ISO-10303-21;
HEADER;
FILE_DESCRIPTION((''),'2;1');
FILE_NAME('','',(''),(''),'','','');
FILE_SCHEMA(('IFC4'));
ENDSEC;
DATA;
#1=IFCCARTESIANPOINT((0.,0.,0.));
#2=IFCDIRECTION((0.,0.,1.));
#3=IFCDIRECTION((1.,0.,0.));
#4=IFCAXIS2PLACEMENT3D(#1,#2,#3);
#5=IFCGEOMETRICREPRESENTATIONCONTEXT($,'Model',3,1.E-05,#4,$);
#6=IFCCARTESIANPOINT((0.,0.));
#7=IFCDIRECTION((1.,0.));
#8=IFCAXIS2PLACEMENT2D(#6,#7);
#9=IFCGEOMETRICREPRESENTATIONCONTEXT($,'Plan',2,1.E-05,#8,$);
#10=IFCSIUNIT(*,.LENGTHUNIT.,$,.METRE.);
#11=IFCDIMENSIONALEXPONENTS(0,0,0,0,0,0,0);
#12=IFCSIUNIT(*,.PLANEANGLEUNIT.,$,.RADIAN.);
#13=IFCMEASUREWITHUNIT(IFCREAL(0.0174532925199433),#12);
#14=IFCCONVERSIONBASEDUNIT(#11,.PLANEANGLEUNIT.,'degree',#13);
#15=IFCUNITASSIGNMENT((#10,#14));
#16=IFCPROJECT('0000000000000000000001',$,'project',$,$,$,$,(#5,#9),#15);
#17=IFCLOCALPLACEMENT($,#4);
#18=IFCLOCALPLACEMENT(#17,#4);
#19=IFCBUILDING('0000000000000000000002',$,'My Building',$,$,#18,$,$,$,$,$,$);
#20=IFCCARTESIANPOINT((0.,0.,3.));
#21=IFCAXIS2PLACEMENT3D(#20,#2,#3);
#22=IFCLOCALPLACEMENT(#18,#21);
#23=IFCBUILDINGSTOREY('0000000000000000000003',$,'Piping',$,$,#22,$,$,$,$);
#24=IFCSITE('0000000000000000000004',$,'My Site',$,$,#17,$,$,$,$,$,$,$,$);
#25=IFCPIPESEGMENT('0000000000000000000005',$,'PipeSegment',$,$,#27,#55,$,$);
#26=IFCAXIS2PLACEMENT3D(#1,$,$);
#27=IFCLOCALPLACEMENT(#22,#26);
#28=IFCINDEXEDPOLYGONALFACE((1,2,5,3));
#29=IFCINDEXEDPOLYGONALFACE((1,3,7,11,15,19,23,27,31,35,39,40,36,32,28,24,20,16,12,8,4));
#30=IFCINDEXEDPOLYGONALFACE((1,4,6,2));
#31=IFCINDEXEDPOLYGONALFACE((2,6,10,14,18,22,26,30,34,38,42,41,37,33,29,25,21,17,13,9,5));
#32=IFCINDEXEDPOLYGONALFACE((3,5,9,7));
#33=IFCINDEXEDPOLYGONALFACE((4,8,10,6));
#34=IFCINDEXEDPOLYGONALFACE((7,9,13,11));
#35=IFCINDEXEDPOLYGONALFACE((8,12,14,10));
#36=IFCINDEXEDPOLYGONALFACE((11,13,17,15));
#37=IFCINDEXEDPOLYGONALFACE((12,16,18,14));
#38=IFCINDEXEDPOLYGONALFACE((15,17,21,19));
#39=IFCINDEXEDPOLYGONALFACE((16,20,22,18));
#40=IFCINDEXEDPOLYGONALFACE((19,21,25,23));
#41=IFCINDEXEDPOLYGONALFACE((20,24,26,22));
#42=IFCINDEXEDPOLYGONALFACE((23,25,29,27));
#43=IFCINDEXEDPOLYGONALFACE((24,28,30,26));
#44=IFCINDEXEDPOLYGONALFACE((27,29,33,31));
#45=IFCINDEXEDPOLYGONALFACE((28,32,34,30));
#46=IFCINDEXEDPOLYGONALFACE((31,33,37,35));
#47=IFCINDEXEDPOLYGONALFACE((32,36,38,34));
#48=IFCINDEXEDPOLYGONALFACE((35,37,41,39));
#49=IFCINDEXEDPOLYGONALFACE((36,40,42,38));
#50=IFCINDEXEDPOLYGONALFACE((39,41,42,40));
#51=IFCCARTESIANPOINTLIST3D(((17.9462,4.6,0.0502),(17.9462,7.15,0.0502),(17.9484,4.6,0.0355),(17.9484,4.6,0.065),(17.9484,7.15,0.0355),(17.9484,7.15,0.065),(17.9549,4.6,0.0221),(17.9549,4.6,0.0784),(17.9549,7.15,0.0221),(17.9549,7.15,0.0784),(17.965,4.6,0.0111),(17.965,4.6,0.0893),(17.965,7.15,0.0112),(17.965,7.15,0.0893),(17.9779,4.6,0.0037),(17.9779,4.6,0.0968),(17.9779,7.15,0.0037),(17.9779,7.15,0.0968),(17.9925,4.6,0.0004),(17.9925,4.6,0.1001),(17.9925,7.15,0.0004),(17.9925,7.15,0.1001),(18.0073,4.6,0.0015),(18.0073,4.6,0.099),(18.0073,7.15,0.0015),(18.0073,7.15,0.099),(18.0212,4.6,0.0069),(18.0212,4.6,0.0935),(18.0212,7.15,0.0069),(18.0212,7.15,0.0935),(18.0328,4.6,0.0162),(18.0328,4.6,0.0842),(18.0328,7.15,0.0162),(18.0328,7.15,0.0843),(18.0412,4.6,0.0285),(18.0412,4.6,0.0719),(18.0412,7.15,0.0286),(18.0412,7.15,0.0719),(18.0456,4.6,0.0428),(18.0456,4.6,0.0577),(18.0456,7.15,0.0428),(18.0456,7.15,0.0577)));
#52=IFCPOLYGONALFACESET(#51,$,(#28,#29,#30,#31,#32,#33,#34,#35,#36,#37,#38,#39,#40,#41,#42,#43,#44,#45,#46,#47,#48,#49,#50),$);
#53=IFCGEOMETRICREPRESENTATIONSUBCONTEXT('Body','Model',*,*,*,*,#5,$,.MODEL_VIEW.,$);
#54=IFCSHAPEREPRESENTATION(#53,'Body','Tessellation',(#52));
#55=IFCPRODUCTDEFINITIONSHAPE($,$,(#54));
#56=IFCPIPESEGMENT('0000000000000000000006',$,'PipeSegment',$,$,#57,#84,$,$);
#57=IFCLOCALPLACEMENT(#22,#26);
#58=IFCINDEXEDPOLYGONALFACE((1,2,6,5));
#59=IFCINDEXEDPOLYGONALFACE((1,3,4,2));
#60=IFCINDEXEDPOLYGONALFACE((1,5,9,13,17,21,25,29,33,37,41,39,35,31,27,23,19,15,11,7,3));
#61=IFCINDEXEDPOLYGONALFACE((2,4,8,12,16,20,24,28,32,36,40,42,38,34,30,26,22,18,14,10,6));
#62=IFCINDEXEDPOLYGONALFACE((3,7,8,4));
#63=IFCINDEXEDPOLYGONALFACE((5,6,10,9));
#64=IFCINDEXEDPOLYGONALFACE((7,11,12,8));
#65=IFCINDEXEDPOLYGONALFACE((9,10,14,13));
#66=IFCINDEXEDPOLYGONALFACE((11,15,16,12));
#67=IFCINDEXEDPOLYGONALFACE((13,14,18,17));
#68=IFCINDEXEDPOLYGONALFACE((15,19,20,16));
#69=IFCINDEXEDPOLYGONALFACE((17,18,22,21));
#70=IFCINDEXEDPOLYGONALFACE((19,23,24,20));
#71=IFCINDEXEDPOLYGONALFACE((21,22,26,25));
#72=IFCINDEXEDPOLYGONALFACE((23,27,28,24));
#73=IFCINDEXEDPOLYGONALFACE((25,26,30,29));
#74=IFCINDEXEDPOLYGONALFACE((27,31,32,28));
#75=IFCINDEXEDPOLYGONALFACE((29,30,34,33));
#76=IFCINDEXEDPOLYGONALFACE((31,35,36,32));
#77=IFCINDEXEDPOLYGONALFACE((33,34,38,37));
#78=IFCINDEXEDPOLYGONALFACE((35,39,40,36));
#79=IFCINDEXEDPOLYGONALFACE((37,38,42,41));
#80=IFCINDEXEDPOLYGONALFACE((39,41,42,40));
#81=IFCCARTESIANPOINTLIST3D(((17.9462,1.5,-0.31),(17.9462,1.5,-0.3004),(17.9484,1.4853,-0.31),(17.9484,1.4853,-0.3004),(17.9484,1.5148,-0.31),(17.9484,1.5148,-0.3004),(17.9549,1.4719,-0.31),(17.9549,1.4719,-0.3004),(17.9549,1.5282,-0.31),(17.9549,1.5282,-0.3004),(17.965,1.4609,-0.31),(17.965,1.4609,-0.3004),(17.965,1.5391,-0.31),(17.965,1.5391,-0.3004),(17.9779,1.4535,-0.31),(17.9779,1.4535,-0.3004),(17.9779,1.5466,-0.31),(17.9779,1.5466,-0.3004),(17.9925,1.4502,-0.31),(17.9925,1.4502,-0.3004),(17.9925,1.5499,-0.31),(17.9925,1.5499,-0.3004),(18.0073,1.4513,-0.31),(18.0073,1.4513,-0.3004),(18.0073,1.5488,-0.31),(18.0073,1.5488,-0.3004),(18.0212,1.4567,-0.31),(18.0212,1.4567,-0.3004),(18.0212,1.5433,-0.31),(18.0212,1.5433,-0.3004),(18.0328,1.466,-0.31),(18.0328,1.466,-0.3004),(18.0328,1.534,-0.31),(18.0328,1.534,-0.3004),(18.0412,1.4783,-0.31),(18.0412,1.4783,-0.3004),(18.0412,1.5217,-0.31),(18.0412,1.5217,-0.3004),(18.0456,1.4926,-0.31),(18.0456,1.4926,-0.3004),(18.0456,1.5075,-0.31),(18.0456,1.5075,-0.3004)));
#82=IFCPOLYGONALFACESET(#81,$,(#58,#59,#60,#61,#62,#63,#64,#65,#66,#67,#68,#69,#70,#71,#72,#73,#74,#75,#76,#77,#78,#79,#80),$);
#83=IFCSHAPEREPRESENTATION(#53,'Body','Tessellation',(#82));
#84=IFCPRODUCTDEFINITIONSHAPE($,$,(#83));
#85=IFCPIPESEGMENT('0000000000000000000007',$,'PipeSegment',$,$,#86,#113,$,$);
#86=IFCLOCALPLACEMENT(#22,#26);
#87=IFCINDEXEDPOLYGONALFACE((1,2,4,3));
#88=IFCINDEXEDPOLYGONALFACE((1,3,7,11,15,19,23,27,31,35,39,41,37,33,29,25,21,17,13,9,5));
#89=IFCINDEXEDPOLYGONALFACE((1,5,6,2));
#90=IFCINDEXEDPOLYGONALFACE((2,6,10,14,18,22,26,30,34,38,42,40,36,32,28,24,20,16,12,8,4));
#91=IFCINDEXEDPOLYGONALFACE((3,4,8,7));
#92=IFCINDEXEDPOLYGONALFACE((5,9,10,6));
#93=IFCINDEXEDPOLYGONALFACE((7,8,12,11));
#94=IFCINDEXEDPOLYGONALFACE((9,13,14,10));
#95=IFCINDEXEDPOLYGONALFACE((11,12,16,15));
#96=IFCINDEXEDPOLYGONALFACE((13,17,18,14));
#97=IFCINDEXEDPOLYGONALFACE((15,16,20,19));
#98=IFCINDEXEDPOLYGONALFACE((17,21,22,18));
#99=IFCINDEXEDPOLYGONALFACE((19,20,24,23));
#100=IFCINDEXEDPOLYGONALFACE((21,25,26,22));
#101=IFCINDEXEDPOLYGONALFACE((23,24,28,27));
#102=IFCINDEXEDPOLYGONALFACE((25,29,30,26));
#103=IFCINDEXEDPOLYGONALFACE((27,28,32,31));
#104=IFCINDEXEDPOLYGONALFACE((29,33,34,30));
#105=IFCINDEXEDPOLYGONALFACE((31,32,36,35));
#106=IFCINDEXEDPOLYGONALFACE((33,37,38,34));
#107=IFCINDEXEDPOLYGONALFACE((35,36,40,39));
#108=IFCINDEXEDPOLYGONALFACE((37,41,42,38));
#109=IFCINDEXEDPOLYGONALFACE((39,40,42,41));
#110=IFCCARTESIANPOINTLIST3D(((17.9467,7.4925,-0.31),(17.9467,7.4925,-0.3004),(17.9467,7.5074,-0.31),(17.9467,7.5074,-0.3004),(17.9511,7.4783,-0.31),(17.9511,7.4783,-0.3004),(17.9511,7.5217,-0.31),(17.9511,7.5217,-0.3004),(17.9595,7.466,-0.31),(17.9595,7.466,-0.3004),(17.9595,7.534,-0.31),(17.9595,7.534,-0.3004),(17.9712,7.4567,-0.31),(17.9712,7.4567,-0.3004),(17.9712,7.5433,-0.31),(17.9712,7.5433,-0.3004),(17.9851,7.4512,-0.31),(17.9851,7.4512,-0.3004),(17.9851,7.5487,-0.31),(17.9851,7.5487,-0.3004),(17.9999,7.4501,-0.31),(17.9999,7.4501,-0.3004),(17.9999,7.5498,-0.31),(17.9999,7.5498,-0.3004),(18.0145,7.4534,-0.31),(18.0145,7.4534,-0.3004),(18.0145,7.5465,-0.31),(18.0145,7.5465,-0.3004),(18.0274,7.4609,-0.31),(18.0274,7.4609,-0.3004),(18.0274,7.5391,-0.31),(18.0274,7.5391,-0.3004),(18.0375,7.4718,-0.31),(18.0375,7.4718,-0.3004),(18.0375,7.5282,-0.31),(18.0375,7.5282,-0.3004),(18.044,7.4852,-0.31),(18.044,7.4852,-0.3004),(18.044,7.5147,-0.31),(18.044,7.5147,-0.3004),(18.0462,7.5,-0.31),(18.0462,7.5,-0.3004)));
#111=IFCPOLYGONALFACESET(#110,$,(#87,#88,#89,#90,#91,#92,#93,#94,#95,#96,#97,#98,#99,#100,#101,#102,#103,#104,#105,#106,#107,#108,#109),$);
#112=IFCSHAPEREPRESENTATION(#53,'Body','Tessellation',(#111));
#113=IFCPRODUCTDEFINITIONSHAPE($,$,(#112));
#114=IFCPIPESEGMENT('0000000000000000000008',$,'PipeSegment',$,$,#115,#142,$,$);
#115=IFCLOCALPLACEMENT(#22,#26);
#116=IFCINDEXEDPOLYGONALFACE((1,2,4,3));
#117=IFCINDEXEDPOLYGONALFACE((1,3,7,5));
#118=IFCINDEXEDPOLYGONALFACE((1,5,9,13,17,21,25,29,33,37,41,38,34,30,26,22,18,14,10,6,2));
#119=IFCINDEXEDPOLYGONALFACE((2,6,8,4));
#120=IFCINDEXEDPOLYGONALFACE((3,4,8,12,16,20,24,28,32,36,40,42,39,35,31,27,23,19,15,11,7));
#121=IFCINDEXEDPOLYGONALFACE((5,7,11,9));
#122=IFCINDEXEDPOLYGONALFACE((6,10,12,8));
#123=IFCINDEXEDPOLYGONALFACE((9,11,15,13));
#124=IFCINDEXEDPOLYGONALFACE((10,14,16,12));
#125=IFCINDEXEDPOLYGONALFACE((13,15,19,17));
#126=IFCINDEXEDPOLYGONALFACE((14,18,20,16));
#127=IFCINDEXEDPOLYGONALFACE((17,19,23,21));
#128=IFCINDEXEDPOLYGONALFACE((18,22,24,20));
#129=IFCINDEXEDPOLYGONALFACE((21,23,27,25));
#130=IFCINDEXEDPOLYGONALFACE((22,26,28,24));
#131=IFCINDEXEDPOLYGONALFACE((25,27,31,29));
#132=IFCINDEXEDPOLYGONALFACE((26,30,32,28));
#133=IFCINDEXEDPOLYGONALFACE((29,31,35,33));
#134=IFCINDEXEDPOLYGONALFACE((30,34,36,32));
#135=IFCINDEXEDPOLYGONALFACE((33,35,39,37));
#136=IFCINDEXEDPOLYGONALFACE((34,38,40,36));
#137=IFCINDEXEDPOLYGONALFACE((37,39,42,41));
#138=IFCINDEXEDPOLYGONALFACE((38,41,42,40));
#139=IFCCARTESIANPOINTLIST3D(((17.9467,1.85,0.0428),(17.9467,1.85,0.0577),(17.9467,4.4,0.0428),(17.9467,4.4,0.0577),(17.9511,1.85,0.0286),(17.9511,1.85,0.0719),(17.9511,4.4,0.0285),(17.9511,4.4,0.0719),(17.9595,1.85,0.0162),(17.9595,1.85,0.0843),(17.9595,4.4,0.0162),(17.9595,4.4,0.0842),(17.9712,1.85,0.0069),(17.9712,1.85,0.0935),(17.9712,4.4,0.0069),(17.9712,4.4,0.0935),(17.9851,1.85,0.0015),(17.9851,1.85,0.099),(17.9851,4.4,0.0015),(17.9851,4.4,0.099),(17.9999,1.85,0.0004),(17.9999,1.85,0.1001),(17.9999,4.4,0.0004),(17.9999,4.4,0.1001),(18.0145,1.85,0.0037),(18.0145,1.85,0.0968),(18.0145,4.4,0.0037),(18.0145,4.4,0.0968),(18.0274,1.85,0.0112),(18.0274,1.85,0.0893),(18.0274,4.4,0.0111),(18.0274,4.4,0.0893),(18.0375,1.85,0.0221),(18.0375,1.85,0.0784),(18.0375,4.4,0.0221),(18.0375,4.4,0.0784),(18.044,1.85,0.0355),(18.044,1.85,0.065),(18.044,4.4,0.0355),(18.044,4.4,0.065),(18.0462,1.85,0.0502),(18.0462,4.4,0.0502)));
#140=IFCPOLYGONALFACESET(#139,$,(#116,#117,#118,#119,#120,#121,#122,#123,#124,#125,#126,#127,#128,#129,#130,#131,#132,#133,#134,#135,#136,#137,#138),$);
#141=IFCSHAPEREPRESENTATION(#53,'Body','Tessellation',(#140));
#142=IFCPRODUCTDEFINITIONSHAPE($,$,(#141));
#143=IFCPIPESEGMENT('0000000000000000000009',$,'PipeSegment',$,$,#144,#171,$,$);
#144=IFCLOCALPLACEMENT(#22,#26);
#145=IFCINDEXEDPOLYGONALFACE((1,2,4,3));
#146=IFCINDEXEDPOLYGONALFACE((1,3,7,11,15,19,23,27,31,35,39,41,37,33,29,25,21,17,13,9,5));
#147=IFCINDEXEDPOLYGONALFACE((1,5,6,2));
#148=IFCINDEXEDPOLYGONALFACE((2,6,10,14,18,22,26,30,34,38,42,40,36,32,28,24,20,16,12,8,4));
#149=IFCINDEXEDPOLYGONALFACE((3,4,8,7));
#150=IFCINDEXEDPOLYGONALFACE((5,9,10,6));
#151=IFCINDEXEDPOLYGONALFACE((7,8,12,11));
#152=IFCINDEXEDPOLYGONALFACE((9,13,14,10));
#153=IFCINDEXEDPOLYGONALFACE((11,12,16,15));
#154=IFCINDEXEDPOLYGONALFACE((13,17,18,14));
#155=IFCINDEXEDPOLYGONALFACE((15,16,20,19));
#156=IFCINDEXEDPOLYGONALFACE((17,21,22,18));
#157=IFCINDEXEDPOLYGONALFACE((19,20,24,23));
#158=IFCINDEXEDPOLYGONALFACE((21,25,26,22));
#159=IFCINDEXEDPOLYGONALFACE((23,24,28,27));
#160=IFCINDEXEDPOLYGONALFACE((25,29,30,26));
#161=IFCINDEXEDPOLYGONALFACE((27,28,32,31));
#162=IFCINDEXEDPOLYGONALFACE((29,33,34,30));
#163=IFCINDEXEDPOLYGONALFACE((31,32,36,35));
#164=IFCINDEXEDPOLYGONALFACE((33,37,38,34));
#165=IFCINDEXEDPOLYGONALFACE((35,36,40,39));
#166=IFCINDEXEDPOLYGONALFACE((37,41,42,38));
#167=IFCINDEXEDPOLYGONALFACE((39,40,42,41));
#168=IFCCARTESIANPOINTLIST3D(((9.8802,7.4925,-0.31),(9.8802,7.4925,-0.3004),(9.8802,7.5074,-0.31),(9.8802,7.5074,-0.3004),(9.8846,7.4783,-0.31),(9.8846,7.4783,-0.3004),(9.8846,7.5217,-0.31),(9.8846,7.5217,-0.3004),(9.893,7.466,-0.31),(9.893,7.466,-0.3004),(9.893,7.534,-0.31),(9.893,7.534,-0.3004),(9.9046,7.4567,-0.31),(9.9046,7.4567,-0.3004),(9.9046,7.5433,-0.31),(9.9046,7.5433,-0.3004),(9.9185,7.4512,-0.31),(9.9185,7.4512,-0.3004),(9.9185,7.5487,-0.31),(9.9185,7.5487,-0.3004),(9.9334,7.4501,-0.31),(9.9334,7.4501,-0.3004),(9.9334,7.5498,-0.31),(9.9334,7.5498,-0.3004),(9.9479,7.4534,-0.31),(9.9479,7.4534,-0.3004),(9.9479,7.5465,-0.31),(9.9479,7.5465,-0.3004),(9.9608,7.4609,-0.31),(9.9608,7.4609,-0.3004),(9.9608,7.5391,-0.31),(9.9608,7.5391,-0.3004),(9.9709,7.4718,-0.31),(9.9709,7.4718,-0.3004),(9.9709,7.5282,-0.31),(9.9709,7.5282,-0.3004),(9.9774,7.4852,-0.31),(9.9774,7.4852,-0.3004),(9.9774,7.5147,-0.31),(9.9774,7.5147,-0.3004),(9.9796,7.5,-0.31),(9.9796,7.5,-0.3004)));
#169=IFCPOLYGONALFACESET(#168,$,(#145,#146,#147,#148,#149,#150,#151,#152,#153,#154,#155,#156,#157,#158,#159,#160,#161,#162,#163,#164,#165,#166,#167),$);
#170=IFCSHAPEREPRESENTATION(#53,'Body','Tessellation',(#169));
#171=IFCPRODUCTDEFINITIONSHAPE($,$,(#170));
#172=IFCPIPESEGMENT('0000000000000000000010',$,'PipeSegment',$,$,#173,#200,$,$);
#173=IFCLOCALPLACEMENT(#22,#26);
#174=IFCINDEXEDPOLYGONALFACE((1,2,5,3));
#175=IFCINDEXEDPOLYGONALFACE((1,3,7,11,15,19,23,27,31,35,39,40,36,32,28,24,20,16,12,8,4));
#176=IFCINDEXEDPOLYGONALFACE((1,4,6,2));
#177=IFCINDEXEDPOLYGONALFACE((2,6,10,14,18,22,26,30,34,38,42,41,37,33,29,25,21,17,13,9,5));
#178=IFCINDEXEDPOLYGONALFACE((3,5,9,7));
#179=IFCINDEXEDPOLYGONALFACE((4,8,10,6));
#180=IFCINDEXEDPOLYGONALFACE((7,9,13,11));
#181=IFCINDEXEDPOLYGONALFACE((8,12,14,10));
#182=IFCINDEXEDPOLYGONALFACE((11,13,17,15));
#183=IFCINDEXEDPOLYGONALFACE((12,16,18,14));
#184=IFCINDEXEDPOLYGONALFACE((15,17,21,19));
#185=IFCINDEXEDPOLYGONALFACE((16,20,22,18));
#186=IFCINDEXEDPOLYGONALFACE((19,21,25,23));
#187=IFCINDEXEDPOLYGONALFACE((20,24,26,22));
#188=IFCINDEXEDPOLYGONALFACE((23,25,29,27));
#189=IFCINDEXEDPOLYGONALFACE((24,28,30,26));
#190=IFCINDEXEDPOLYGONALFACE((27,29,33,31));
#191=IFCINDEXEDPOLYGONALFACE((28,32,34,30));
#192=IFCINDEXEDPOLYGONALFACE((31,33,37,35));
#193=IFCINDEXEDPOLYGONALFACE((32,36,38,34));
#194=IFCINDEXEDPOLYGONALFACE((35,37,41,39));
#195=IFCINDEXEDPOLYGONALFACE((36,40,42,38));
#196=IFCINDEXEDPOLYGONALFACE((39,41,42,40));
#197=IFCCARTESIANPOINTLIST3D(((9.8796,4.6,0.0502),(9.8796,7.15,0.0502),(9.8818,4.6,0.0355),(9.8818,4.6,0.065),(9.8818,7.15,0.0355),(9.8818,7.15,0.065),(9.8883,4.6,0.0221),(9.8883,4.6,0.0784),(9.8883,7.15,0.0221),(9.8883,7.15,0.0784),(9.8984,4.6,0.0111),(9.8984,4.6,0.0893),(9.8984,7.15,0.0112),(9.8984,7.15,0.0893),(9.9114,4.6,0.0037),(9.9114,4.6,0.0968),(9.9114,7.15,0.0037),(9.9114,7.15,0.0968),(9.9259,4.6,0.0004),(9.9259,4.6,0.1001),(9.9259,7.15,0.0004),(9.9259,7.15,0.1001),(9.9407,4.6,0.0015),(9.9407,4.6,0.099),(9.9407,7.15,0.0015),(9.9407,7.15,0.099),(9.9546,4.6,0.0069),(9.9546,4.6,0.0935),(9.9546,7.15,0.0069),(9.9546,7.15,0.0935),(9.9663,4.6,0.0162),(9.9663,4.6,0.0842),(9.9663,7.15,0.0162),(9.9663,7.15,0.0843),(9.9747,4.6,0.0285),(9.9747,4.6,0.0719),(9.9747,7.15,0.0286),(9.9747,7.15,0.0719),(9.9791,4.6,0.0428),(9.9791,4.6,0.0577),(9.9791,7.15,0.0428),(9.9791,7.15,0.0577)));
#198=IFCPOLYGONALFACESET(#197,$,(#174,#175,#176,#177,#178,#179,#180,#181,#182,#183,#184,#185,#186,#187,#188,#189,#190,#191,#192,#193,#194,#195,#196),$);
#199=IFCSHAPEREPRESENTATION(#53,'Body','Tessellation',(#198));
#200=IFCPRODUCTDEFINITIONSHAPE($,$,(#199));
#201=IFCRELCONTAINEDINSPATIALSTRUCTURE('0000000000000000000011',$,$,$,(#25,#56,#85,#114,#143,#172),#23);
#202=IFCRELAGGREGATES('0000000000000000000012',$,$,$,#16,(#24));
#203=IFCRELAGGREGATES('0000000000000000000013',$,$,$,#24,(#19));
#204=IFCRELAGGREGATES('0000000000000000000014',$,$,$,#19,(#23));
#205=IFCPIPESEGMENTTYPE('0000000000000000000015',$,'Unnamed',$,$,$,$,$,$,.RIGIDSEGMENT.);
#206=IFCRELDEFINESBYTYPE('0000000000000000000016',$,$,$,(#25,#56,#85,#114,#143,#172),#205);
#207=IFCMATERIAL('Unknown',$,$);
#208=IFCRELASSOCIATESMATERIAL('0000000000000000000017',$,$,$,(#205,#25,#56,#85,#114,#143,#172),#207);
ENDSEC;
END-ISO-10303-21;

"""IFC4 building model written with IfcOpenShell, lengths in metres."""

from ifc_helpers import new_model, entity, si_unit, converted_unit, frame, origin_with_axes, origin_2d_with_axis, place, context, subcontext, project, spatial, circle, extrude, material, material_profile, profile_set, profile_usage, type_object, element, save


model = new_model("IFC4")

# Units and contexts
model_context = context("Model", 3, precision=1e-05, world=origin_with_axes())
plan_context = context("Plan", 2, precision=1e-05, world=origin_2d_with_axis())
body_context = subcontext(model_context, "Body", "Model", "MODEL_VIEW")
ifc_project = project(units=[si_unit("LENGTHUNIT", "METRE"), converted_unit("PLANEANGLEUNIT", "degree", entity("IfcReal", 0.0174532925199433), si_unit("PLANEANGLEUNIT", "RADIAN"), dimensions=[0, 0, 0, 0, 0, 0, 0])], contexts=[model_context, plan_context])

# Site, building, storey
site_placement = place(None, origin_with_axes())
site = spatial("IfcSite", under=ifc_project, at=site_placement, Name="My Site")
building_placement = place(site_placement, origin_with_axes())
building = spatial("IfcBuilding", under=site, at=building_placement, Name="My Building")
storey_placement = place(building_placement, frame((0.0, 0.0, 3.0), z_axis=(0.0, 0.0, 1.0), x_axis=(1.0, 0.0, 0.0)))
storey = spatial("IfcBuildingStorey", under=building, at=storey_placement, Name="Piping")

# Pipe segments
ifc_material = material(Name="Unknown")
ifc_material_profile_1 = material_profile(ifc_material, circle(Radius=0.05))
ifc_profile_set_1 = profile_set([ifc_material_profile_1])
ifc_profile_usage_1 = profile_usage(ifc_profile_set_1, cardinal=2)
pipe_segment_type = type_object("IfcPipeSegmentType", Name="Unnamed", PredefinedType="RIGIDSEGMENT", material=ifc_profile_set_1)
pipe_segment_1_placement = place(storey_placement, frame((17.9962, 4.6, 0.0002), z_axis=(0.0, 1.0, 0.000006), x_axis=(-1.0, 0.0, 0.0)))
element("IfcPipeSegment", 1, at=pipe_segment_1_placement, inside=storey, type_object=pipe_segment_type, material=ifc_profile_usage_1, Name="PipeSegment", context=body_context, shape_type="SweptSolid", body=[
    extrude(circle(Radius=0.05), frame((0.0, 0.05, 0.0), z_axis=(0.0, 0.0, 1.0), x_axis=(1.0, 0.0, 0.0)), (0.0, 0.0, 1.0), 2.55),
])
ifc_profile_usage_2 = profile_usage(ifc_profile_set_1, cardinal=16)
pipe_segment_2_placement = place(storey_placement, frame((17.9962, 1.5, -0.3004), z_axis=(0.0, 0.0, -1.0), x_axis=(-1.0, 0.0, 0.0)))
element("IfcPipeSegment", 2, at=pipe_segment_2_placement, inside=storey, type_object=pipe_segment_type, material=ifc_profile_usage_2, Name="PipeSegment", context=body_context, shape_type="SweptSolid", body=[
    extrude(circle(Radius=0.05), origin_with_axes(), (0.0, 0.0, 1.0), 0.0096),
])
ifc_profile_usage_3 = profile_usage(ifc_profile_set_1, cardinal=16)
pipe_segment_3_placement = place(storey_placement, frame((17.9962, 7.5, -0.3004), z_axis=(0.0, 0.0, -1.0), x_axis=(1.0, 0.0, 0.0)))
element("IfcPipeSegment", 3, at=pipe_segment_3_placement, inside=storey, type_object=pipe_segment_type, material=ifc_profile_usage_3, Name="PipeSegment", context=body_context, shape_type="SweptSolid", body=[
    extrude(circle(Radius=0.05), origin_with_axes(), (0.0, 0.0, 1.0), 0.0096),
])
ifc_profile_usage_4 = profile_usage(ifc_profile_set_1, cardinal=2)
pipe_segment_4_placement = place(storey_placement, frame((17.9962, 4.4, 0.0002), z_axis=(0.0, -1.0, 0.000006), x_axis=(1.0, 0.0, 0.0)))
element("IfcPipeSegment", 4, at=pipe_segment_4_placement, inside=storey, type_object=pipe_segment_type, material=ifc_profile_usage_4, Name="PipeSegment", context=body_context, shape_type="SweptSolid", body=[
    extrude(circle(Radius=0.05), frame((0.0, 0.05, 0.0), z_axis=(0.0, 0.0, 1.0), x_axis=(1.0, 0.0, 0.0)), (0.0, 0.0, 1.0), 2.55),
])
ifc_profile_usage_5 = profile_usage(ifc_profile_set_1, cardinal=16)
pipe_segment_5_placement = place(storey_placement, frame((9.9296, 7.5, -0.3004), z_axis=(0.0, 0.0, -1.0), x_axis=(1.0, 0.0, 0.0)))
element("IfcPipeSegment", 5, at=pipe_segment_5_placement, inside=storey, type_object=pipe_segment_type, material=ifc_profile_usage_5, Name="PipeSegment", context=body_context, shape_type="SweptSolid", body=[
    extrude(circle(Radius=0.05), origin_with_axes(), (0.0, 0.0, 1.0), 0.0096),
])
ifc_profile_usage_6 = profile_usage(ifc_profile_set_1, cardinal=2)
pipe_segment_6_placement = place(storey_placement, frame((9.9296, 4.6, 0.0002), z_axis=(0.0, 1.0, 0.000006), x_axis=(-1.0, 0.0, 0.0)))
element("IfcPipeSegment", 6, at=pipe_segment_6_placement, inside=storey, type_object=pipe_segment_type, material=ifc_profile_usage_6, Name="PipeSegment", context=body_context, shape_type="SweptSolid", body=[
    extrude(circle(Radius=0.05), frame((0.0, 0.05, 0.0), z_axis=(0.0, 0.0, 1.0), x_axis=(1.0, 0.0, 0.0)), (0.0, 0.0, 1.0), 2.55),
])

save(model, "model.ifc")
